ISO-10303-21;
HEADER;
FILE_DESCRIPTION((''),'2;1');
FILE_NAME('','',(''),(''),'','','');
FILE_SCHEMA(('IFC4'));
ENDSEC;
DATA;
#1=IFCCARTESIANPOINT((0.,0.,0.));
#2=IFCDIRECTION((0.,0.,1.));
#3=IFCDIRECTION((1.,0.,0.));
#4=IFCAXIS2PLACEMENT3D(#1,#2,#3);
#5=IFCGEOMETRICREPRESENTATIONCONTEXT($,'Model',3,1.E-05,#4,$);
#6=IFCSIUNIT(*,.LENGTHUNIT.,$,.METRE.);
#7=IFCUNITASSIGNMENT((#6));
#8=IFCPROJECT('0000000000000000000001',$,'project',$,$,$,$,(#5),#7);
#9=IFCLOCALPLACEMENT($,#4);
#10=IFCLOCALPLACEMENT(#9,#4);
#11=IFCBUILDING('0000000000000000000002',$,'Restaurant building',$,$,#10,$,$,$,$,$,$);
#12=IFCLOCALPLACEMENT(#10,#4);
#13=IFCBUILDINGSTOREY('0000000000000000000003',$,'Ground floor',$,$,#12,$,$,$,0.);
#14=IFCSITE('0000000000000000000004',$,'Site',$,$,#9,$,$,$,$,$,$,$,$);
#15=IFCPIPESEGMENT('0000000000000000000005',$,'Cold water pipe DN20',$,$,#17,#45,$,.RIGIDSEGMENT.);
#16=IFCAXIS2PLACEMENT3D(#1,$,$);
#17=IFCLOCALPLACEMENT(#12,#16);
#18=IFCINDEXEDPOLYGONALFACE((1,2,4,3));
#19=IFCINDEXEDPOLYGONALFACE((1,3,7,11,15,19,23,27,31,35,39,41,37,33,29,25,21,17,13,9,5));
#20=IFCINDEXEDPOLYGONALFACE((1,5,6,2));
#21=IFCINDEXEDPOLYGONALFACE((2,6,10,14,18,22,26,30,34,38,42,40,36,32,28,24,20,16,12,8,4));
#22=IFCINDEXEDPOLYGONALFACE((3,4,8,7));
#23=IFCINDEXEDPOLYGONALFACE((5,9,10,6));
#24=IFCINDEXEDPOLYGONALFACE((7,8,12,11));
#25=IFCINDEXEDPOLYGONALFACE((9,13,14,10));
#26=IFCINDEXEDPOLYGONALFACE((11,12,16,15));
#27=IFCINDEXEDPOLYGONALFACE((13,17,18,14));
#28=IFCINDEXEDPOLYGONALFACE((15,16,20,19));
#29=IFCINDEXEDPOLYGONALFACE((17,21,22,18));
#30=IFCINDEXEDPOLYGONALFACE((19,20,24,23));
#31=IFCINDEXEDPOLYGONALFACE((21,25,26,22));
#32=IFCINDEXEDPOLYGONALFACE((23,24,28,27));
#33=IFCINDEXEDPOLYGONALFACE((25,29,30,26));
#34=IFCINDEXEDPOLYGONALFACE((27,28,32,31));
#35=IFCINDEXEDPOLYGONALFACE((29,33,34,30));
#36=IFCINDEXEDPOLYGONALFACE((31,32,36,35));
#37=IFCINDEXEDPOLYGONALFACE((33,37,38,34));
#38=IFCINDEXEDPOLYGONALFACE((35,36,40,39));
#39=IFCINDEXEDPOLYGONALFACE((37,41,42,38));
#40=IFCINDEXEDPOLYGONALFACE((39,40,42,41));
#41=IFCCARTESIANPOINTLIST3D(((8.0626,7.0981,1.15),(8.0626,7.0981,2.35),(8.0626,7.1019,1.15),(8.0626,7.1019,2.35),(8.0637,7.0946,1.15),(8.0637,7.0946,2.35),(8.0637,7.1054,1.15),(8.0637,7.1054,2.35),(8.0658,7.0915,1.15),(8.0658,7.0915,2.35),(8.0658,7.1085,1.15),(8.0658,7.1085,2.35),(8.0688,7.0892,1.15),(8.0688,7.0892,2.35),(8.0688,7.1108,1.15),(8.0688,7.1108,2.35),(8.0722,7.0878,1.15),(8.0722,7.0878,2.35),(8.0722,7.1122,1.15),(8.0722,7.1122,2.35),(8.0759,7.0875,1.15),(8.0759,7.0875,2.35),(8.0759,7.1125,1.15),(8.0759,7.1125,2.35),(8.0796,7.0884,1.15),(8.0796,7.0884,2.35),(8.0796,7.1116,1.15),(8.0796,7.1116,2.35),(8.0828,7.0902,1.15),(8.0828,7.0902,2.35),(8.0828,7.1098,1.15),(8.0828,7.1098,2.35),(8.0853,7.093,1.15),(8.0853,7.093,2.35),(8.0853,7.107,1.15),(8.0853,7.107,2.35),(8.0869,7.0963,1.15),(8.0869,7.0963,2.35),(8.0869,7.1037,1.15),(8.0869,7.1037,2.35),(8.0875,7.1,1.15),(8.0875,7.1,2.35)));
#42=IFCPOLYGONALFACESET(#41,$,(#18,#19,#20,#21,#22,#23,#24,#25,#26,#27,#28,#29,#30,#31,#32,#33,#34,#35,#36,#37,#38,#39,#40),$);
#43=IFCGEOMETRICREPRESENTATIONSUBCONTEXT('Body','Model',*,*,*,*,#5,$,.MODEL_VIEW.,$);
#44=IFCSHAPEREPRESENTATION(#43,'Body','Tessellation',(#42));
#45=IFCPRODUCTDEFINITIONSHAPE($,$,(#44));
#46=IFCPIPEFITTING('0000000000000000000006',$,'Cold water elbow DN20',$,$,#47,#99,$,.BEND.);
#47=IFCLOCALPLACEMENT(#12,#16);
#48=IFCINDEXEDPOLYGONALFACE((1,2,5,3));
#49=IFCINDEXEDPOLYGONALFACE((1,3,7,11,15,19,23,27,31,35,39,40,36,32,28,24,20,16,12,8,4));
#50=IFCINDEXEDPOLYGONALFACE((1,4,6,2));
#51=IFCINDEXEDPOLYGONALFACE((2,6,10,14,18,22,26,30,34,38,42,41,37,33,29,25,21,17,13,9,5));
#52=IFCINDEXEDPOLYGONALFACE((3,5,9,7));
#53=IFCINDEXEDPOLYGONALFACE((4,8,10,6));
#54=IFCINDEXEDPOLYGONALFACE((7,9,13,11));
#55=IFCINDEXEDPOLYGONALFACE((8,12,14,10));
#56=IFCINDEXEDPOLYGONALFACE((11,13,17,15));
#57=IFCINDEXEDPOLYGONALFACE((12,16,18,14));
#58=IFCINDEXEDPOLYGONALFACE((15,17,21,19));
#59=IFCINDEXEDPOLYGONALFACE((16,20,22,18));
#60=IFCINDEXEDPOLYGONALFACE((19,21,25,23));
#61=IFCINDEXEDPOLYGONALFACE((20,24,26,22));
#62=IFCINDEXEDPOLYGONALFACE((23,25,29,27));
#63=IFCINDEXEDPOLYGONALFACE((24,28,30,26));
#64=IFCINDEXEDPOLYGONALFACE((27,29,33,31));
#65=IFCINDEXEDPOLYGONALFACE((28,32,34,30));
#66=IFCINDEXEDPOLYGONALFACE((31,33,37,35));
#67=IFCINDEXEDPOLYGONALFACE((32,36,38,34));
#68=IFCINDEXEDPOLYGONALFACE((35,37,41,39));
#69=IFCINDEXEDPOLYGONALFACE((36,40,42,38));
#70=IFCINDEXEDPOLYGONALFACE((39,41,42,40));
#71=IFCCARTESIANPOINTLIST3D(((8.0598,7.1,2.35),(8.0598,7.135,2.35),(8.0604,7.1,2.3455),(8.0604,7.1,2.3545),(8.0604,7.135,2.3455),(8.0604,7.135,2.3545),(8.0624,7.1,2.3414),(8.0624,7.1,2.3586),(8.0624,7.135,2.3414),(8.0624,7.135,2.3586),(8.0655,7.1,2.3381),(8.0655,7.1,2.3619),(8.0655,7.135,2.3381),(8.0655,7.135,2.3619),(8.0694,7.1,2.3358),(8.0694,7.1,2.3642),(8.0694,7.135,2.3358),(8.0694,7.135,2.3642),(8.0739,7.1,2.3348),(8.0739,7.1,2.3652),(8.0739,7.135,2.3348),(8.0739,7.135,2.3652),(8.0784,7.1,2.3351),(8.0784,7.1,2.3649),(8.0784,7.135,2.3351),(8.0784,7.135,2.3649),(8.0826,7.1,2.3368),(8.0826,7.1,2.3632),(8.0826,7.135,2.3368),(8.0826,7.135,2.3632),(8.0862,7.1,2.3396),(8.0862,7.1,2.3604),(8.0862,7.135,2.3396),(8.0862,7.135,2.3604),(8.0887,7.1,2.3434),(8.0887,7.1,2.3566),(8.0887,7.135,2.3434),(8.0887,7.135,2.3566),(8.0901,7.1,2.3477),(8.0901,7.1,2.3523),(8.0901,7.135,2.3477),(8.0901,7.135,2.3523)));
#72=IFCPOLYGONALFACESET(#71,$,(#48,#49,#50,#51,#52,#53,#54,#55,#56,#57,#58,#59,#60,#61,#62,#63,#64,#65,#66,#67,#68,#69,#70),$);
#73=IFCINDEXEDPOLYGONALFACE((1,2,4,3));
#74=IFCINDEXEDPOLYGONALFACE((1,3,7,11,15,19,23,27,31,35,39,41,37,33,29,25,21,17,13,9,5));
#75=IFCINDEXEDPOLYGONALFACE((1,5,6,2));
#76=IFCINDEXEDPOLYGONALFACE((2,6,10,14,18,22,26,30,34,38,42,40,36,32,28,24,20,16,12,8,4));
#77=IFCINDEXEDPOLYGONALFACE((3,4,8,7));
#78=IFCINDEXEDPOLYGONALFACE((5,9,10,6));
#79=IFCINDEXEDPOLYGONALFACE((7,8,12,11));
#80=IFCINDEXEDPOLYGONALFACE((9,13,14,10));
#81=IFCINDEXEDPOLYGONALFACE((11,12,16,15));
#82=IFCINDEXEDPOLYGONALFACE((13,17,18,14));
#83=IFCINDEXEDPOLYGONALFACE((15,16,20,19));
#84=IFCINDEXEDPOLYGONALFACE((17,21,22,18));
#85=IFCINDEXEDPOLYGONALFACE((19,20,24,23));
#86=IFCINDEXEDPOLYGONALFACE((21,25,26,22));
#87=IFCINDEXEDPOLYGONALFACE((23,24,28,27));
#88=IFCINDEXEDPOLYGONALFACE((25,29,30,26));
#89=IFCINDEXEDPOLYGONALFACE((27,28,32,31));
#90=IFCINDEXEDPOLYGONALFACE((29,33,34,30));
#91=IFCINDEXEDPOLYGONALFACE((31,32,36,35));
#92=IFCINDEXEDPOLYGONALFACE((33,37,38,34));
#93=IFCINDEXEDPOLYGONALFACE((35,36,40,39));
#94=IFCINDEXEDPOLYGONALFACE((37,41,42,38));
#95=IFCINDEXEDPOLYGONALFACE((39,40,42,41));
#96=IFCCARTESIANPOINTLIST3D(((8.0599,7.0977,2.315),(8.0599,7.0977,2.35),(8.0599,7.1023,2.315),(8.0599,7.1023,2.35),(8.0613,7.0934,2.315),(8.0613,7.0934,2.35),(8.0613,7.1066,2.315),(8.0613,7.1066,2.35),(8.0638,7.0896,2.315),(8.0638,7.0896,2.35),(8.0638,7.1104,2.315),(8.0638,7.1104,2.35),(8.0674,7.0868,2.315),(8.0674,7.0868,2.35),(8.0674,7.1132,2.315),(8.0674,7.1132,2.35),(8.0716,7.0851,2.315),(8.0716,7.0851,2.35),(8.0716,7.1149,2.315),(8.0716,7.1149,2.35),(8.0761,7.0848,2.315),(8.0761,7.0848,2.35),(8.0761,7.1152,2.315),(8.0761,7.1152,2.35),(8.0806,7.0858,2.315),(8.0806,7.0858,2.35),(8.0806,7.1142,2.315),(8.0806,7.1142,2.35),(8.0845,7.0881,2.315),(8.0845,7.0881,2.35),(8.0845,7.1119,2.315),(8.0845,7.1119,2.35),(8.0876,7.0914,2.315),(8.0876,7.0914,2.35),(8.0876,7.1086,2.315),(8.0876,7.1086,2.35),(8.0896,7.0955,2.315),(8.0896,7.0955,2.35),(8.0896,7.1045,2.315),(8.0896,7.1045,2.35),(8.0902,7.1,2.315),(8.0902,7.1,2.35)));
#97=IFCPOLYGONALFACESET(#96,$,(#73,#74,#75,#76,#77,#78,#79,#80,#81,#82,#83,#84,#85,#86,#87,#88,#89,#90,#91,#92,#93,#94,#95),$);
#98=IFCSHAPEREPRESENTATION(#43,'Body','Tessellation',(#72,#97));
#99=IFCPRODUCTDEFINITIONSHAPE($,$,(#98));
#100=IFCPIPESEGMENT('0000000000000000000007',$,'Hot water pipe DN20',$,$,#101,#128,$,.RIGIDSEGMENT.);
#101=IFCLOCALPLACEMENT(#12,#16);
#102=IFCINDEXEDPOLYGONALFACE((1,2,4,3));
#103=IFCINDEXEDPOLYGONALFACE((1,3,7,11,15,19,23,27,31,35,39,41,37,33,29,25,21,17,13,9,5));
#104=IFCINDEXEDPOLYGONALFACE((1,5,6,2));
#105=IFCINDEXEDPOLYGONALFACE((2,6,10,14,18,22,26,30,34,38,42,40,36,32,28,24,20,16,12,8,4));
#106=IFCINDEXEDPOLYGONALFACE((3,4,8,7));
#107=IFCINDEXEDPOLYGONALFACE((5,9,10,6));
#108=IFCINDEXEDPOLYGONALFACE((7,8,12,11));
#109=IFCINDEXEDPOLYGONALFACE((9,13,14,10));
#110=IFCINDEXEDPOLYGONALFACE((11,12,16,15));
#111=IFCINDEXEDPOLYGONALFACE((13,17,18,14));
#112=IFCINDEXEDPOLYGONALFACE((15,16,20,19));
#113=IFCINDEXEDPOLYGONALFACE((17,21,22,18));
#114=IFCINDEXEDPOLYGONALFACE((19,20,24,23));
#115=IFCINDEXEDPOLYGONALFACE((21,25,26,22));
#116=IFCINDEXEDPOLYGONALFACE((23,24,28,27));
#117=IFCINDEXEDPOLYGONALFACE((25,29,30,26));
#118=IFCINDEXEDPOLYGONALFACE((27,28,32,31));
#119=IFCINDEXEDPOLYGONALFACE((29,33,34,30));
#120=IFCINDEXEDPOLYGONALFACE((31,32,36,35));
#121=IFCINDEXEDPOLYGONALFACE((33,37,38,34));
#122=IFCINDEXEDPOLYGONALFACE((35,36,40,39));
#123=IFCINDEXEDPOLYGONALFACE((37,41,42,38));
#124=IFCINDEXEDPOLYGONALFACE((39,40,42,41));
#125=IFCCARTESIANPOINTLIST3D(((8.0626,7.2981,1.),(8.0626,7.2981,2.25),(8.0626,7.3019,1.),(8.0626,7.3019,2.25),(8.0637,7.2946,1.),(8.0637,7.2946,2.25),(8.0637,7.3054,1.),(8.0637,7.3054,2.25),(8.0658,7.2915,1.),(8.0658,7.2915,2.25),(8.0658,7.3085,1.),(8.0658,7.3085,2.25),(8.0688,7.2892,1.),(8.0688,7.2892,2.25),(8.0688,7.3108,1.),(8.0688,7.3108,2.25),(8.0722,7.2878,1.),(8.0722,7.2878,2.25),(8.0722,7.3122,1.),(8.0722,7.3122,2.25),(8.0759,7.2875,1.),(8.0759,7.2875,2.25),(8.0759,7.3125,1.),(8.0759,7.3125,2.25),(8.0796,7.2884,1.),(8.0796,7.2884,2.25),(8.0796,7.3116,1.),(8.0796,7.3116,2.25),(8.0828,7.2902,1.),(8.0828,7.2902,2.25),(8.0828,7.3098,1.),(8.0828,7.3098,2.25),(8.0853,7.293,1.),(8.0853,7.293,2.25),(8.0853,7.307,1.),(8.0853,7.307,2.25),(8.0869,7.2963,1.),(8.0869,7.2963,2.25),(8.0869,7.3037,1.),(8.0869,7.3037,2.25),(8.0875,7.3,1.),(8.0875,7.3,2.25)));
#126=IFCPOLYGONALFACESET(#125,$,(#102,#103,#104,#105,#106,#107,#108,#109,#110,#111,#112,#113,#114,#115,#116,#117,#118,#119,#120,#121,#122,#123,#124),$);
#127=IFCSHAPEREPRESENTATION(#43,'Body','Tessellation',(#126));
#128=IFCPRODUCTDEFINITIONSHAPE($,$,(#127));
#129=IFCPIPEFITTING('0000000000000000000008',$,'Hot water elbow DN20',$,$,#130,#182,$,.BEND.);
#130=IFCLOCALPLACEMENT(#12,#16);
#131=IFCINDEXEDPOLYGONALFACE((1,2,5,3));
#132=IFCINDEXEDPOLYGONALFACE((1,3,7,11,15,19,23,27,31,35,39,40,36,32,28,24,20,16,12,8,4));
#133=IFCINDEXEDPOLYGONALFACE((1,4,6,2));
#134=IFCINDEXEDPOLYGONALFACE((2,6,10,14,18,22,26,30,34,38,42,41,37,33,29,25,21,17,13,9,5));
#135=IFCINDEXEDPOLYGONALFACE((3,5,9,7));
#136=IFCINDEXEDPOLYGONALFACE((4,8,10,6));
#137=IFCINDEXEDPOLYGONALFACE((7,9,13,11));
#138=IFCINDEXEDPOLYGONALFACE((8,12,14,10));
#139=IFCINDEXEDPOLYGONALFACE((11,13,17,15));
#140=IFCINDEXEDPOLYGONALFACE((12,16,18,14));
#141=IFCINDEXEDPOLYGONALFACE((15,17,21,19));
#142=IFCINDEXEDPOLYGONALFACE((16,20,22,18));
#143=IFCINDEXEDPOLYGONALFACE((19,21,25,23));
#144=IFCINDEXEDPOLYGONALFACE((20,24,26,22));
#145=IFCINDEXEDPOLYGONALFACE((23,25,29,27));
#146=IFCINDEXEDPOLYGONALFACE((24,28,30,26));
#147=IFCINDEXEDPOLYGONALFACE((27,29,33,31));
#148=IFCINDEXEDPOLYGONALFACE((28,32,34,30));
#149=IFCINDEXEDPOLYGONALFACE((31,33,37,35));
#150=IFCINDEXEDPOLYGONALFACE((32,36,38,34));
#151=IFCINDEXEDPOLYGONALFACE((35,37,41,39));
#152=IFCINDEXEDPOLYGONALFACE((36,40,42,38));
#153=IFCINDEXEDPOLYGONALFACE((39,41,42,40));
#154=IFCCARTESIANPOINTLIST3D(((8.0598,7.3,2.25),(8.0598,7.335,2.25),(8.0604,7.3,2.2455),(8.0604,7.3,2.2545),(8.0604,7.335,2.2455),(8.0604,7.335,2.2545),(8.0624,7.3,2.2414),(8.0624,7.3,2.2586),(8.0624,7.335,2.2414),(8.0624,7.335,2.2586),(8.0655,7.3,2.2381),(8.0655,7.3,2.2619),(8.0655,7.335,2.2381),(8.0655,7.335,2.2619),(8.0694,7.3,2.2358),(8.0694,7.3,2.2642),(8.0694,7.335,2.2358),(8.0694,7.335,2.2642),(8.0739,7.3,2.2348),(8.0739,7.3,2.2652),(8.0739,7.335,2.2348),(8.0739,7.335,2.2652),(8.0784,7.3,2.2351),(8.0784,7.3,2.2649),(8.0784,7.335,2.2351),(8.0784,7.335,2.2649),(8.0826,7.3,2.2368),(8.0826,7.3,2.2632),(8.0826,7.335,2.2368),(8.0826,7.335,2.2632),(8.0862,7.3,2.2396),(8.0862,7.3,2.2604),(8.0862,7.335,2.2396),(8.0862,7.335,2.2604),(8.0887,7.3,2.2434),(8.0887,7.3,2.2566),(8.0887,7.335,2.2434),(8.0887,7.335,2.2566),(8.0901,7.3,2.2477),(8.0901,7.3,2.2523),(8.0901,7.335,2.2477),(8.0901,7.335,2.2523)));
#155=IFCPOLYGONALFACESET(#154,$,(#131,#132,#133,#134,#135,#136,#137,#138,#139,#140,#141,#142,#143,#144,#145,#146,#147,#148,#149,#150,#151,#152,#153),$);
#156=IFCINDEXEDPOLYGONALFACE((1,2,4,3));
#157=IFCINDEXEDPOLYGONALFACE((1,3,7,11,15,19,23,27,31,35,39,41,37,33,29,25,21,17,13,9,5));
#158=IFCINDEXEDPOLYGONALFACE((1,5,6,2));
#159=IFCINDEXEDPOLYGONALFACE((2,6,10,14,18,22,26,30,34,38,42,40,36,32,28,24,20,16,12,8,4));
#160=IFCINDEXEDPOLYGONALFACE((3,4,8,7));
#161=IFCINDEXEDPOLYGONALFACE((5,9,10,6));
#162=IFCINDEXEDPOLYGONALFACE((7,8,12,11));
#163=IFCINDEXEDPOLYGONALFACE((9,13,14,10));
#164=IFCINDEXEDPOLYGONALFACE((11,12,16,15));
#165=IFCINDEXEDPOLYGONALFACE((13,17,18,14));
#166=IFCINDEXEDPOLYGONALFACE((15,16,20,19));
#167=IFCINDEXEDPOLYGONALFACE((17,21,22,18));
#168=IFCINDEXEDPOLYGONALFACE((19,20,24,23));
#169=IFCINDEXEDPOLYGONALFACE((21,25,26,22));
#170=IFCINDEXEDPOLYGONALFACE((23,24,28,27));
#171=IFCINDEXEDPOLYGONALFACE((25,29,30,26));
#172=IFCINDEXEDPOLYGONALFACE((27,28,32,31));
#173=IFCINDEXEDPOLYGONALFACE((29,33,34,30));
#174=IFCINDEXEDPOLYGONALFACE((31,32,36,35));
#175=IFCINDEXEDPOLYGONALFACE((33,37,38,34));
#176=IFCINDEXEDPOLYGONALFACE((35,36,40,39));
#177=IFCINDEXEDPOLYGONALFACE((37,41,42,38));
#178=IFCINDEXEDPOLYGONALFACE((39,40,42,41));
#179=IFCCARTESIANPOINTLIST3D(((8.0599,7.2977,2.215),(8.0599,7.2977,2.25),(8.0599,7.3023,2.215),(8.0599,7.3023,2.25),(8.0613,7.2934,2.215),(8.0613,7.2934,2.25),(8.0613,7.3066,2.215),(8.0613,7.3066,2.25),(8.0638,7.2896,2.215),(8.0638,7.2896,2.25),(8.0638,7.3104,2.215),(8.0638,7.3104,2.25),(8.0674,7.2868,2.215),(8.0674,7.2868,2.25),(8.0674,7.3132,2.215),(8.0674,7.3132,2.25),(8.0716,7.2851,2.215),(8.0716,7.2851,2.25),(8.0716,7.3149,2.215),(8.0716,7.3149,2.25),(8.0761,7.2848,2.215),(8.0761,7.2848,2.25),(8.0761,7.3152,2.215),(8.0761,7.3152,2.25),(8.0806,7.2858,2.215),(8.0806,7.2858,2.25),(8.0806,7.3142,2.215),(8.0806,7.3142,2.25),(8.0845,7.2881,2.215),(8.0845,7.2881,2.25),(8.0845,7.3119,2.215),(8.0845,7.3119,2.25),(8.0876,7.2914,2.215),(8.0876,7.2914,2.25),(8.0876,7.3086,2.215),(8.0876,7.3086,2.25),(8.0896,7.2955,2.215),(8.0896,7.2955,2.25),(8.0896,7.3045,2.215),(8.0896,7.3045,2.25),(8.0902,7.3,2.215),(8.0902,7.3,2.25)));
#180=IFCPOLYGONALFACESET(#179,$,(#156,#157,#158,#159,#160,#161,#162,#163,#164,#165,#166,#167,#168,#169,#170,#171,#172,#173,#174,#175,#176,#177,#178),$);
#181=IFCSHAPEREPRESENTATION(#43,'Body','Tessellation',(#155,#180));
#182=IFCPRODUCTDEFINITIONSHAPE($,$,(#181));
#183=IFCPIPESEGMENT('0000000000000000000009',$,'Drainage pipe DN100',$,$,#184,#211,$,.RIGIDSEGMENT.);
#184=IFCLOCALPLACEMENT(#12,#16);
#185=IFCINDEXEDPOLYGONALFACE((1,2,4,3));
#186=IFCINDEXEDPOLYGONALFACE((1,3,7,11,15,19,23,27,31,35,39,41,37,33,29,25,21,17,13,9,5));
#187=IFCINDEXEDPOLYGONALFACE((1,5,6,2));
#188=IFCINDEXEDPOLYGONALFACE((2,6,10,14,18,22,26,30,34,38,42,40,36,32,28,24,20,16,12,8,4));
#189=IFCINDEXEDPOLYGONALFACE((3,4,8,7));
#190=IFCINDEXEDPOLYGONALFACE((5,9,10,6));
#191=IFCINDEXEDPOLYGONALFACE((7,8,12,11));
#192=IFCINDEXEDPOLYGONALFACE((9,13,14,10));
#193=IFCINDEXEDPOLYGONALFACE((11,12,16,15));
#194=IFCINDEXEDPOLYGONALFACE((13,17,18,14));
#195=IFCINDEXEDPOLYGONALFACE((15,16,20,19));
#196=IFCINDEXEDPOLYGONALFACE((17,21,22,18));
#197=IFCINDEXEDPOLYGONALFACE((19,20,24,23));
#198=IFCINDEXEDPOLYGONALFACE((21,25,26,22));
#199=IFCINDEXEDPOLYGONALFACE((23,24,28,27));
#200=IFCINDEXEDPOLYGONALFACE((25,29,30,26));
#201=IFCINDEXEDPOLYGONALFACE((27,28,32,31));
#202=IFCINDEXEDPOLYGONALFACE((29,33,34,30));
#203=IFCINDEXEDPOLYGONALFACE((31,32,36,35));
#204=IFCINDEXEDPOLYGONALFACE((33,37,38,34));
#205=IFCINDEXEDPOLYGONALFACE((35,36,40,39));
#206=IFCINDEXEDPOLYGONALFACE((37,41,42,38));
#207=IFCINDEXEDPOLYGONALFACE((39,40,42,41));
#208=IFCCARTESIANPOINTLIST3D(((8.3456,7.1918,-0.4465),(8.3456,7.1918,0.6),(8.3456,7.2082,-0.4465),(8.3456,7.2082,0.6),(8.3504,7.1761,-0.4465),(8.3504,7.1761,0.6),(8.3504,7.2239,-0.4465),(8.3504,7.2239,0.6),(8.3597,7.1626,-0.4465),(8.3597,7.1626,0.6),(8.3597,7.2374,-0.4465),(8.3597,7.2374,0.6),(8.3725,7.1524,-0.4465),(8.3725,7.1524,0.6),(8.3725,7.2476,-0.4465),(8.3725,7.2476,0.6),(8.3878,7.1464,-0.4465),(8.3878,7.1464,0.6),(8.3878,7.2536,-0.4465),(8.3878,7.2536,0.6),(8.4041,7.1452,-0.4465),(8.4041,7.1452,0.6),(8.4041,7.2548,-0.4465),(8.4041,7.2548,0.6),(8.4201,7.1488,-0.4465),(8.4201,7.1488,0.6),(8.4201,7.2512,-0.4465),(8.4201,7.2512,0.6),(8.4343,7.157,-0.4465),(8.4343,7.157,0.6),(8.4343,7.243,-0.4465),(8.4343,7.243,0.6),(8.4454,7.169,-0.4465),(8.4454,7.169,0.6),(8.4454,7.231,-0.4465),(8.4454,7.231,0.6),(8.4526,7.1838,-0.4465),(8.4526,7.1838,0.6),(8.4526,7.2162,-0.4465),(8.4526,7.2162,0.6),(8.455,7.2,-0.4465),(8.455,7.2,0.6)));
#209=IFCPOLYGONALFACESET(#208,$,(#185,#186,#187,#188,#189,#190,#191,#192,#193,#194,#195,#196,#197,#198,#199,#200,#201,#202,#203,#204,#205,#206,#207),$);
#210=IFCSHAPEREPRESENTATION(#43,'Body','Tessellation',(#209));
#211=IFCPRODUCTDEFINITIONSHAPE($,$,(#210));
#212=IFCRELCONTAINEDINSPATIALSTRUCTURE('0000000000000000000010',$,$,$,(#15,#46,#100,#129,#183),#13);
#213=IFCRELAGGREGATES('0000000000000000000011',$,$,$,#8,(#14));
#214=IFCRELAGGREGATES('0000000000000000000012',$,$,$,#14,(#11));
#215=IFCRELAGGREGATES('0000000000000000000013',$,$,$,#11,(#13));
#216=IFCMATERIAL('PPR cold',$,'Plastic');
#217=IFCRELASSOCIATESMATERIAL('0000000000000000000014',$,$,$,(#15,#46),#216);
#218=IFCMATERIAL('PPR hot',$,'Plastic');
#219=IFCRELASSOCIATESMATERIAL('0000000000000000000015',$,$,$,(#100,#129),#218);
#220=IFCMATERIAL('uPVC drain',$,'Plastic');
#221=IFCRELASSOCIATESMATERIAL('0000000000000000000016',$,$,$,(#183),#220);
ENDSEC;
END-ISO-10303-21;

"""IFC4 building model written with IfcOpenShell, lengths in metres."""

from ifc_helpers import new_model, si_unit, frame, origin_with_axes, origin_2d, place, context, subcontext, project, spatial, circle, extrude, material, element, save


model = new_model("IFC4")

# Units and contexts
model_context = context("Model", 3, precision=1e-05, world=origin_with_axes())
body_context = subcontext(model_context, "Body", "Model", "MODEL_VIEW")
ifc_project = project(units=[si_unit("LENGTHUNIT", "METRE")], contexts=[model_context])

# Site, building, storey
site_placement = place(None, origin_with_axes())
site = spatial("IfcSite", under=ifc_project, at=site_placement, Name="Site")
building_placement = place(site_placement, origin_with_axes())
building = spatial("IfcBuilding", under=site, at=building_placement, Name="Restaurant building")
storey_placement = place(building_placement, origin_with_axes())
storey = spatial("IfcBuildingStorey", under=building, at=storey_placement, Name="Ground floor", Elevation=0.0)

# Pipe segment
ifc_material_1 = material(Name="PPR cold", Category="Plastic")
pipe_segment_1_placement = place(storey_placement, frame((8.075, 7.1, 2.35)))
element("IfcPipeSegment", 1, at=pipe_segment_1_placement, inside=storey, material=ifc_material_1, Name="Cold water pipe DN20", PredefinedType="RIGIDSEGMENT", context=body_context, shape_type="SweptSolid", body=[
    extrude(circle(Radius=0.0125, at=origin_2d()), frame((0.0, 0.0, 0.0), z_axis=(0.0, 0.0, -1.0), x_axis=(1.0, 0.0, 0.0)), (0.0, 0.0, 1.0), 1.2),
])

# Pipe fitting
pipe_fitting_1_placement = place(storey_placement, frame((8.075, 7.1, 2.35)))
element("IfcPipeFitting", 2, at=pipe_fitting_1_placement, inside=storey, material=ifc_material_1, Name="Cold water elbow DN20", PredefinedType="BEND", context=body_context, shape_type="SweptSolid", body=[
    extrude(circle(Radius=0.0152, at=origin_2d()), frame((0.0, 0.0, 0.0), z_axis=(0.0, 1.0, 0.0), x_axis=(-1.0, 0.0, 0.0)), (0.0, 0.0, 1.0), 0.035),
    extrude(circle(Radius=0.0152, at=origin_2d()), frame((0.0, 0.0, 0.0), z_axis=(0.0, 0.0, -1.0), x_axis=(1.0, 0.0, 0.0)), (0.0, 0.0, 1.0), 0.035),
])

# Pipe segment
ifc_material_2 = material(Name="PPR hot", Category="Plastic")
pipe_segment_2_placement = place(storey_placement, frame((8.075, 7.3, 2.25)))
element("IfcPipeSegment", 3, at=pipe_segment_2_placement, inside=storey, material=ifc_material_2, Name="Hot water pipe DN20", PredefinedType="RIGIDSEGMENT", context=body_context, shape_type="SweptSolid", body=[
    extrude(circle(Radius=0.0125, at=origin_2d()), frame((0.0, 0.0, 0.0), z_axis=(0.0, 0.0, -1.0), x_axis=(1.0, 0.0, 0.0)), (0.0, 0.0, 1.0), 1.25),
])

# Pipe fitting
pipe_fitting_2_placement = place(storey_placement, frame((8.075, 7.3, 2.25)))
element("IfcPipeFitting", 4, at=pipe_fitting_2_placement, inside=storey, material=ifc_material_2, Name="Hot water elbow DN20", PredefinedType="BEND", context=body_context, shape_type="SweptSolid", body=[
    extrude(circle(Radius=0.0152, at=origin_2d()), frame((0.0, 0.0, 0.0), z_axis=(0.0, 1.0, 0.0), x_axis=(-1.0, 0.0, 0.0)), (0.0, 0.0, 1.0), 0.035),
    extrude(circle(Radius=0.0152, at=origin_2d()), frame((0.0, 0.0, 0.0), z_axis=(0.0, 0.0, -1.0), x_axis=(1.0, 0.0, 0.0)), (0.0, 0.0, 1.0), 0.035),
])

# Pipe segment
ifc_material_3 = material(Name="uPVC drain", Category="Plastic")
pipe_segment_3_placement = place(storey_placement, frame((8.4, 7.2, 0.6)))
element("IfcPipeSegment", 5, at=pipe_segment_3_placement, inside=storey, material=ifc_material_3, Name="Drainage pipe DN100", PredefinedType="RIGIDSEGMENT", context=body_context, shape_type="SweptSolid", body=[
    extrude(circle(Radius=0.055, at=origin_2d()), frame((0.0, 0.0, 0.0), z_axis=(0.0, 0.0, -1.0), x_axis=(1.0, 0.0, 0.0)), (0.0, 0.0, 1.0), 1.0465),
])

save(model, "model.ifc")
